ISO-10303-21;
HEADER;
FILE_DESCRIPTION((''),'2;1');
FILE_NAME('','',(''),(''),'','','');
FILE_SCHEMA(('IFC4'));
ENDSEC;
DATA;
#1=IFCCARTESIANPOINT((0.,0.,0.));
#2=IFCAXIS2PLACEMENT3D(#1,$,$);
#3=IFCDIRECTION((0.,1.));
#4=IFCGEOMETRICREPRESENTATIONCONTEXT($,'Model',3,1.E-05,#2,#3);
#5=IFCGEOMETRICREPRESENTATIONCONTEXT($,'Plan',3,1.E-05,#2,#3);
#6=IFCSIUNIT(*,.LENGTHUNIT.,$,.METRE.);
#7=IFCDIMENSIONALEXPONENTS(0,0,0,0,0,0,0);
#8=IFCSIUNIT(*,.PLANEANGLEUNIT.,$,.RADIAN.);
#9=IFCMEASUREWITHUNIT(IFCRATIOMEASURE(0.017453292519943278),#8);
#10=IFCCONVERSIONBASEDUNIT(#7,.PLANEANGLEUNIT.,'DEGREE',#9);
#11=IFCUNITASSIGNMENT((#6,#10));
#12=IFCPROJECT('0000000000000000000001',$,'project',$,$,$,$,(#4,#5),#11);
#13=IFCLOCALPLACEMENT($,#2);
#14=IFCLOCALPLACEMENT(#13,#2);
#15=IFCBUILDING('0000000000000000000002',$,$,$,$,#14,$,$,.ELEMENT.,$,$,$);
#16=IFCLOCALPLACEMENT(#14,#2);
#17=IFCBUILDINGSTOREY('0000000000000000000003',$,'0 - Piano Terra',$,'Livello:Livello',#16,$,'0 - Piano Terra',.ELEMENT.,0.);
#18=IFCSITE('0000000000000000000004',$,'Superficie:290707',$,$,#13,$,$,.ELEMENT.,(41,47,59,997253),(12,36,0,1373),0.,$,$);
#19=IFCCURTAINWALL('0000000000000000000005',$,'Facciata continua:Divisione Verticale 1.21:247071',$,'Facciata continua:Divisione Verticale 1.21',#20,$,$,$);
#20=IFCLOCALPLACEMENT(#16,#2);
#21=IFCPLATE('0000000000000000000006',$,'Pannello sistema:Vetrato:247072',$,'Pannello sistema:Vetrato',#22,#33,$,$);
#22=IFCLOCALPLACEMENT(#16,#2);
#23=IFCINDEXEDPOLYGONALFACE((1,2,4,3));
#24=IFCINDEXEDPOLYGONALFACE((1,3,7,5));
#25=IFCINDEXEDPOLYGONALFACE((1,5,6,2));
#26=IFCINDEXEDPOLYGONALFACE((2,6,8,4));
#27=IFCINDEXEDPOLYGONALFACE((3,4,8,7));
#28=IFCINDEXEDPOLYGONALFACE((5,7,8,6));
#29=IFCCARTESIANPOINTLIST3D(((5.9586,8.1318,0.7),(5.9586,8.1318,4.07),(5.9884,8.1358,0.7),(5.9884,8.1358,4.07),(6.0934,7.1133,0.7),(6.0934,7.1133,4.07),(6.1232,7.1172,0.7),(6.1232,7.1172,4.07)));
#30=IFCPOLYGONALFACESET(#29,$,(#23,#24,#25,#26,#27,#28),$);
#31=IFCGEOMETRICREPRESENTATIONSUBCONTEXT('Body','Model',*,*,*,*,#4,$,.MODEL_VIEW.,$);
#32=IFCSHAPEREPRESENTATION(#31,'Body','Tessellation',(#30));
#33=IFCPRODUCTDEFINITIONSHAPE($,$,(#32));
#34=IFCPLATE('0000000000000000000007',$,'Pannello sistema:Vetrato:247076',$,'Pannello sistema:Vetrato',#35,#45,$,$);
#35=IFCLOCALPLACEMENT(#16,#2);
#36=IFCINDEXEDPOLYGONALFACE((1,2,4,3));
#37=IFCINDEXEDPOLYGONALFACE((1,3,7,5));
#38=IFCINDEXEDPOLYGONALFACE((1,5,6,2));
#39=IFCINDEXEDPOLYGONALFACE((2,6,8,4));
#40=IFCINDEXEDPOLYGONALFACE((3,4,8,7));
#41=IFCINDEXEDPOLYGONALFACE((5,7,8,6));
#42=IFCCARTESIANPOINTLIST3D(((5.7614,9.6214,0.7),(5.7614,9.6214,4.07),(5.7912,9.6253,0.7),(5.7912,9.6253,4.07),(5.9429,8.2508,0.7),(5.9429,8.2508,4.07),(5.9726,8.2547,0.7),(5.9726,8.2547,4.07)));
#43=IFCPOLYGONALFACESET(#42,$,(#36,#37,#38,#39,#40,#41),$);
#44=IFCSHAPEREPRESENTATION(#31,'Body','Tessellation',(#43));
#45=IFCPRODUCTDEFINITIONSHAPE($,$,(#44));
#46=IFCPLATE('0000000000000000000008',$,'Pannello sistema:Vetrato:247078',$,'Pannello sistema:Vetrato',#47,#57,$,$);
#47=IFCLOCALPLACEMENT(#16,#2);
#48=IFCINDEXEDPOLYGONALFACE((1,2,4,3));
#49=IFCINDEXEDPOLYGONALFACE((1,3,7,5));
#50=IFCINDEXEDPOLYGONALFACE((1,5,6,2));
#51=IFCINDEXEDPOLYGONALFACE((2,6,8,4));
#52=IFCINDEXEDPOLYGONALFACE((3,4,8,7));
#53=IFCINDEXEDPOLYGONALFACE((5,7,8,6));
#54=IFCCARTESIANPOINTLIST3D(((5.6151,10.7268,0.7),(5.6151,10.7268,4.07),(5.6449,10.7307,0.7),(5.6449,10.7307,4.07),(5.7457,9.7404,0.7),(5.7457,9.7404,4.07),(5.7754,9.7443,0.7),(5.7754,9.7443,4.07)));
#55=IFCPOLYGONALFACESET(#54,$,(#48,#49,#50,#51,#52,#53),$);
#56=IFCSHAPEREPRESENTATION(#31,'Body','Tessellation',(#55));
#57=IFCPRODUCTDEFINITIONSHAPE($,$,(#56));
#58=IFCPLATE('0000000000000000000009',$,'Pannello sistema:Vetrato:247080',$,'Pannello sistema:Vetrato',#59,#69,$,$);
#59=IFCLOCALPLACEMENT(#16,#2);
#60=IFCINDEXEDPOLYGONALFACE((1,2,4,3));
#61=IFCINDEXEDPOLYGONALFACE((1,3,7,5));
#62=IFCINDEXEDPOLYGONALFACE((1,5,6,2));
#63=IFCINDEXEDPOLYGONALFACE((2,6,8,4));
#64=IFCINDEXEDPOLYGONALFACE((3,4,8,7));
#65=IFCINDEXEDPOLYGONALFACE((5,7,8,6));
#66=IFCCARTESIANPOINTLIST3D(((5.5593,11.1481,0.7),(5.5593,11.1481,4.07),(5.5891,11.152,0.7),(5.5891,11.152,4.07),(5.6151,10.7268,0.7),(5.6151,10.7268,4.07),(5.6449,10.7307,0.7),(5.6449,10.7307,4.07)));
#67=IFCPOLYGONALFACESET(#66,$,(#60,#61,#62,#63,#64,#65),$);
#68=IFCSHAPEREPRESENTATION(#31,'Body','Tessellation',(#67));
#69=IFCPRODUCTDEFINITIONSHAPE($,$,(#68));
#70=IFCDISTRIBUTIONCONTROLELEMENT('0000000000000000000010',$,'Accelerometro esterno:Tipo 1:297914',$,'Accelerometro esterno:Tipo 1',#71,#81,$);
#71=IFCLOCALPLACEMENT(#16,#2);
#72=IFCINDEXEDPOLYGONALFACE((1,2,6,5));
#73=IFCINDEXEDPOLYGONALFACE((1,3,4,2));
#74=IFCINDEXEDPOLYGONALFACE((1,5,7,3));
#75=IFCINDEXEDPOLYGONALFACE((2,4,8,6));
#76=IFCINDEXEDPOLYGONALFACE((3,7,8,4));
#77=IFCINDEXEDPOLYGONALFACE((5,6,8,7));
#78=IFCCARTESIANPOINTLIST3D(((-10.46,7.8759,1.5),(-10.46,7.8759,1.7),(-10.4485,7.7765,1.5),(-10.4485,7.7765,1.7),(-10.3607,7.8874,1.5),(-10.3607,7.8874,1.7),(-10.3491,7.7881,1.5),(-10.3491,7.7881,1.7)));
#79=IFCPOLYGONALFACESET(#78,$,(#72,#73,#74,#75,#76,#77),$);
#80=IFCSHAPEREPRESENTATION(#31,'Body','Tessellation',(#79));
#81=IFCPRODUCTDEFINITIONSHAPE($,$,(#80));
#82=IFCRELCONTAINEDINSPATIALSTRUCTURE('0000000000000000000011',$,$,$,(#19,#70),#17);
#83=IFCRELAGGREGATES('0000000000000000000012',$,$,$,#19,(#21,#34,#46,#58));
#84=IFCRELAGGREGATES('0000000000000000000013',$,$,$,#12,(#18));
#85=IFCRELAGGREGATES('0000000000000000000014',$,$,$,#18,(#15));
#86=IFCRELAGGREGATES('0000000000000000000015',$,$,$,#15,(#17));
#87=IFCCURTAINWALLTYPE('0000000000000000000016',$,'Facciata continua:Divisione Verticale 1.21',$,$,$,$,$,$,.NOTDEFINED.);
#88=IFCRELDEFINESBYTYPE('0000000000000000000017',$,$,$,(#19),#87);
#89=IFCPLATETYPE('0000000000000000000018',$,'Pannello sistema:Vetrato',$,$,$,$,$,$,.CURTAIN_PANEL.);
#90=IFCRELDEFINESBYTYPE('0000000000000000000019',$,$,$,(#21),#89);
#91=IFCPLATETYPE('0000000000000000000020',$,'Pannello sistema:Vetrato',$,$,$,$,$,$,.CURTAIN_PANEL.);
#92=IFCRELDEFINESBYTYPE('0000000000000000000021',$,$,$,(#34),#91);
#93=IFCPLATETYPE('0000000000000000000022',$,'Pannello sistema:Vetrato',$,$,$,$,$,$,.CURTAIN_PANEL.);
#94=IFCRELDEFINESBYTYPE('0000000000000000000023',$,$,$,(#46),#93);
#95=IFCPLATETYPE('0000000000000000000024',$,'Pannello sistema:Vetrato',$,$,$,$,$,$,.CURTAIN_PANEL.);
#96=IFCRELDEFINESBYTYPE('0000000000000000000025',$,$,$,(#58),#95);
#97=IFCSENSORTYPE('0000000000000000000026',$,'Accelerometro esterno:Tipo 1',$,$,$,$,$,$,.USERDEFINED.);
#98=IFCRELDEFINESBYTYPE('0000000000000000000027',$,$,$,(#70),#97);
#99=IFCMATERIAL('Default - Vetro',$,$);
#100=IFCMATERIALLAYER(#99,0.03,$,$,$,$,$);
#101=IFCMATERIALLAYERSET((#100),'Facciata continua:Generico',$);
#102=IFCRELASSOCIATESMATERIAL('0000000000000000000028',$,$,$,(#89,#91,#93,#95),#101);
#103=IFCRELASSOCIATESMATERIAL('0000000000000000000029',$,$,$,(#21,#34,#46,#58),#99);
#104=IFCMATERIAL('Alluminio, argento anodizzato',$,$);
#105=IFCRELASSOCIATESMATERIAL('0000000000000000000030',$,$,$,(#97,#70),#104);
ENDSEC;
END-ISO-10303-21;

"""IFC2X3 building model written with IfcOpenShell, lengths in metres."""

from ifc_helpers import new_model, entity, si_unit, converted_unit, direction, frame, frame_2d, origin, place, context, subcontext, project, spatial, rectangle, extrude, source, transform, mapped, material, layer, layer_set, type_object, type_shapes, element, aggregate, save


model = new_model("IFC2X3")

# Units and contexts
model_context = context("Model", 3, precision=1e-05, world=origin(), true_north=direction((0.0, 1.0)))
plan_context = context("Plan", 3, precision=1e-05, world=origin(), true_north=direction((0.0, 1.0)))
body_context = subcontext(model_context, "Body", "Model", "MODEL_VIEW")
ifc_project = project(units=[si_unit("LENGTHUNIT", "METRE"), converted_unit("PLANEANGLEUNIT", "DEGREE", entity("IfcRatioMeasure", 0.017453292519943278), si_unit("PLANEANGLEUNIT", "RADIAN"), dimensions=[0, 0, 0, 0, 0, 0, 0])], contexts=[model_context, plan_context])

# Site, building, storey
site_placement = place(None, origin())
site = spatial("IfcSite", under=ifc_project, at=site_placement, Name="Superficie:290707", CompositionType="ELEMENT", RefLatitude=(41, 47, 59, 997253), RefLongitude=(12, 36, 0, 1373), RefElevation=0.0)
building_placement = place(site_placement, origin())
building = spatial("IfcBuilding", under=site, at=building_placement, CompositionType="ELEMENT")
storey_placement = place(building_placement, origin())
storey = spatial("IfcBuildingStorey", under=building, at=storey_placement, Name="0 - Piano Terra", ObjectType="Livello:Livello", LongName="0 - Piano Terra", CompositionType="ELEMENT", Elevation=0.0)

# Curtain wall
curtain_wall_type_1 = type_object("IfcCurtainWallType", Name="Facciata continua:Divisione Verticale 1.21", PredefinedType="NOTDEFINED")
curtain_wall_1_placement = place(storey_placement, origin())
curtain_wall_1 = element("IfcCurtainWall", 1, at=curtain_wall_1_placement, inside=storey, type_object=curtain_wall_type_1, Name="Facciata continua:Divisione Verticale 1.21:247071", ObjectType="Facciata continua:Divisione Verticale 1.21")

# Shared definitions
ifc_material_1 = material(Name="Default - Vetro")
ifc_layer_1 = layer(ifc_material_1, 0.03)
ifc_layer_set_1 = layer_set([ifc_layer_1], Name="Facciata continua:Generico")

# Plates
plate_type_1 = type_object("IfcPlateType", Name="Pannello sistema:Vetrato", PredefinedType="CURTAIN_PANEL", material=ifc_layer_set_1)
shared_shape_1 = source(origin(), body_context, "Body", "SweptSolid", [
    extrude(rectangle(XDim=0.03, YDim=1.0274, at=frame_2d((0.0, 0.0), x_axis=(1.0, 0.0))), frame((0.0, 0.0, 0.0), z_axis=(0.0, 0.0, 1.0), x_axis=(0.0, 1.0, 0.0)), (0.0, 0.0, 1.0), 3.37),
])
type_shapes(plate_type_1, [shared_shape_1])
plate_1_placement = place(curtain_wall_1_placement, frame((6.0409, 7.6245, 0.7), z_axis=(0.0, 0.0, 1.0), x_axis=(-0.13123, 0.991352, 0.0)))
plate_1 = element("IfcPlate", 2, at=plate_1_placement, type_object=plate_type_1, material=ifc_material_1, Name="Pannello sistema:Vetrato:247072", ObjectType="Pannello sistema:Vetrato", context=body_context, shape_type="MappedRepresentation", body=[
    mapped(shared_shape_1, transform((0.0, 0.0, 0.0), scale=1.0)),
])
plate_type_2 = type_object("IfcPlateType", Name="Pannello sistema:Vetrato", PredefinedType="CURTAIN_PANEL", material=ifc_layer_set_1)
shared_shape_2 = source(origin(), body_context, "Body", "SweptSolid", [
    extrude(rectangle(XDim=0.03, YDim=1.3826, at=frame_2d((0.0, 0.0), x_axis=(1.0, 0.0))), frame((0.0, 0.0, 0.0), z_axis=(0.0, 0.0, 1.0), x_axis=(0.0, 1.0, 0.0)), (0.0, 0.0, 1.0), 3.37),
])
type_shapes(plate_type_2, [shared_shape_2])
plate_2_placement = place(curtain_wall_1_placement, frame((5.867, 8.9381, 0.7), z_axis=(0.0, 0.0, 1.0), x_axis=(-0.13123, 0.991352, 0.0)))
plate_2 = element("IfcPlate", 3, at=plate_2_placement, type_object=plate_type_2, material=ifc_material_1, Name="Pannello sistema:Vetrato:247076", ObjectType="Pannello sistema:Vetrato", context=body_context, shape_type="MappedRepresentation", body=[
    mapped(shared_shape_2, transform((0.0, 0.0, 0.0), scale=1.0)),
])
plate_type_3 = type_object("IfcPlateType", Name="Pannello sistema:Vetrato", PredefinedType="CURTAIN_PANEL", material=ifc_layer_set_1)
shared_shape_3 = source(origin(), body_context, "Body", "SweptSolid", [
    extrude(rectangle(XDim=0.03, YDim=0.995, at=frame_2d((0.0, 0.0), x_axis=(1.0, 0.0))), frame((0.0, 0.0, 0.0), z_axis=(0.0, 0.0, 1.0), x_axis=(0.0, 1.0, 0.0)), (0.0, 0.0, 1.0), 3.37),
])
type_shapes(plate_type_3, [shared_shape_3])
plate_3_placement = place(curtain_wall_1_placement, frame((5.6953, 10.2355, 0.7), z_axis=(0.0, 0.0, 1.0), x_axis=(-0.13123, 0.991352, 0.0)))
plate_3 = element("IfcPlate", 4, at=plate_3_placement, type_object=plate_type_3, material=ifc_material_1, Name="Pannello sistema:Vetrato:247078", ObjectType="Pannello sistema:Vetrato", context=body_context, shape_type="MappedRepresentation", body=[
    mapped(shared_shape_3, transform((0.0, 0.0, 0.0), scale=1.0)),
])
plate_type_4 = type_object("IfcPlateType", Name="Pannello sistema:Vetrato", PredefinedType="CURTAIN_PANEL", material=ifc_layer_set_1)
shared_shape_4 = source(origin(), body_context, "Body", "SweptSolid", [
    extrude(rectangle(XDim=0.03, YDim=0.425, at=frame_2d((0.0, 0.0), x_axis=(1.0, 0.0))), frame((0.0, 0.0, 0.0), z_axis=(0.0, 0.0, 1.0), x_axis=(0.0, 1.0, 0.0)), (0.0, 0.0, 1.0), 3.37),
])
type_shapes(plate_type_4, [shared_shape_4])
plate_4_placement = place(curtain_wall_1_placement, frame((5.6021, 10.9394, 0.7), z_axis=(0.0, 0.0, 1.0), x_axis=(-0.13123, 0.991352, 0.0)))
plate_4 = element("IfcPlate", 5, at=plate_4_placement, type_object=plate_type_4, material=ifc_material_1, Name="Pannello sistema:Vetrato:247080", ObjectType="Pannello sistema:Vetrato", context=body_context, shape_type="MappedRepresentation", body=[
    mapped(shared_shape_4, transform((0.0, 0.0, 0.0), scale=1.0)),
])
aggregate(curtain_wall_1, [plate_1, plate_2, plate_3, plate_4])

# Distribution control element
ifc_material_2 = material(Name="Alluminio, argento anodizzato")
sensor_type = type_object("IfcSensorType", Name="Accelerometro esterno:Tipo 1", PredefinedType="USERDEFINED", material=ifc_material_2)
shared_shape_5 = source(origin(), body_context, "Body", "SweptSolid", [
    extrude(rectangle(XDim=0.1, YDim=0.1, at=frame_2d((0.0, 0.0), x_axis=(1.0, 0.0))), frame((0.05, 0.05, 0.0), z_axis=(0.0, 0.0, 1.0), x_axis=(-1.0, 0.0, 0.0)), (0.0, 0.0, 1.0), 0.2),
])
type_shapes(sensor_type, [shared_shape_5])
distribution_control_element_placement = place(storey_placement, frame((-10.3607, 7.8874, 1.5), z_axis=(0.0, 0.0, 1.0), x_axis=(-0.993306, -0.115509, 0.0)))
element("IfcDistributionControlElement", 6, at=distribution_control_element_placement, inside=storey, type_object=sensor_type, material=ifc_material_2, Name="Accelerometro esterno:Tipo 1:297914", ObjectType="Accelerometro esterno:Tipo 1", context=body_context, shape_type="MappedRepresentation", body=[
    mapped(shared_shape_5, transform((0.0, 0.0, 0.0), scale=1.0)),
])

save(model, "model.ifc")
